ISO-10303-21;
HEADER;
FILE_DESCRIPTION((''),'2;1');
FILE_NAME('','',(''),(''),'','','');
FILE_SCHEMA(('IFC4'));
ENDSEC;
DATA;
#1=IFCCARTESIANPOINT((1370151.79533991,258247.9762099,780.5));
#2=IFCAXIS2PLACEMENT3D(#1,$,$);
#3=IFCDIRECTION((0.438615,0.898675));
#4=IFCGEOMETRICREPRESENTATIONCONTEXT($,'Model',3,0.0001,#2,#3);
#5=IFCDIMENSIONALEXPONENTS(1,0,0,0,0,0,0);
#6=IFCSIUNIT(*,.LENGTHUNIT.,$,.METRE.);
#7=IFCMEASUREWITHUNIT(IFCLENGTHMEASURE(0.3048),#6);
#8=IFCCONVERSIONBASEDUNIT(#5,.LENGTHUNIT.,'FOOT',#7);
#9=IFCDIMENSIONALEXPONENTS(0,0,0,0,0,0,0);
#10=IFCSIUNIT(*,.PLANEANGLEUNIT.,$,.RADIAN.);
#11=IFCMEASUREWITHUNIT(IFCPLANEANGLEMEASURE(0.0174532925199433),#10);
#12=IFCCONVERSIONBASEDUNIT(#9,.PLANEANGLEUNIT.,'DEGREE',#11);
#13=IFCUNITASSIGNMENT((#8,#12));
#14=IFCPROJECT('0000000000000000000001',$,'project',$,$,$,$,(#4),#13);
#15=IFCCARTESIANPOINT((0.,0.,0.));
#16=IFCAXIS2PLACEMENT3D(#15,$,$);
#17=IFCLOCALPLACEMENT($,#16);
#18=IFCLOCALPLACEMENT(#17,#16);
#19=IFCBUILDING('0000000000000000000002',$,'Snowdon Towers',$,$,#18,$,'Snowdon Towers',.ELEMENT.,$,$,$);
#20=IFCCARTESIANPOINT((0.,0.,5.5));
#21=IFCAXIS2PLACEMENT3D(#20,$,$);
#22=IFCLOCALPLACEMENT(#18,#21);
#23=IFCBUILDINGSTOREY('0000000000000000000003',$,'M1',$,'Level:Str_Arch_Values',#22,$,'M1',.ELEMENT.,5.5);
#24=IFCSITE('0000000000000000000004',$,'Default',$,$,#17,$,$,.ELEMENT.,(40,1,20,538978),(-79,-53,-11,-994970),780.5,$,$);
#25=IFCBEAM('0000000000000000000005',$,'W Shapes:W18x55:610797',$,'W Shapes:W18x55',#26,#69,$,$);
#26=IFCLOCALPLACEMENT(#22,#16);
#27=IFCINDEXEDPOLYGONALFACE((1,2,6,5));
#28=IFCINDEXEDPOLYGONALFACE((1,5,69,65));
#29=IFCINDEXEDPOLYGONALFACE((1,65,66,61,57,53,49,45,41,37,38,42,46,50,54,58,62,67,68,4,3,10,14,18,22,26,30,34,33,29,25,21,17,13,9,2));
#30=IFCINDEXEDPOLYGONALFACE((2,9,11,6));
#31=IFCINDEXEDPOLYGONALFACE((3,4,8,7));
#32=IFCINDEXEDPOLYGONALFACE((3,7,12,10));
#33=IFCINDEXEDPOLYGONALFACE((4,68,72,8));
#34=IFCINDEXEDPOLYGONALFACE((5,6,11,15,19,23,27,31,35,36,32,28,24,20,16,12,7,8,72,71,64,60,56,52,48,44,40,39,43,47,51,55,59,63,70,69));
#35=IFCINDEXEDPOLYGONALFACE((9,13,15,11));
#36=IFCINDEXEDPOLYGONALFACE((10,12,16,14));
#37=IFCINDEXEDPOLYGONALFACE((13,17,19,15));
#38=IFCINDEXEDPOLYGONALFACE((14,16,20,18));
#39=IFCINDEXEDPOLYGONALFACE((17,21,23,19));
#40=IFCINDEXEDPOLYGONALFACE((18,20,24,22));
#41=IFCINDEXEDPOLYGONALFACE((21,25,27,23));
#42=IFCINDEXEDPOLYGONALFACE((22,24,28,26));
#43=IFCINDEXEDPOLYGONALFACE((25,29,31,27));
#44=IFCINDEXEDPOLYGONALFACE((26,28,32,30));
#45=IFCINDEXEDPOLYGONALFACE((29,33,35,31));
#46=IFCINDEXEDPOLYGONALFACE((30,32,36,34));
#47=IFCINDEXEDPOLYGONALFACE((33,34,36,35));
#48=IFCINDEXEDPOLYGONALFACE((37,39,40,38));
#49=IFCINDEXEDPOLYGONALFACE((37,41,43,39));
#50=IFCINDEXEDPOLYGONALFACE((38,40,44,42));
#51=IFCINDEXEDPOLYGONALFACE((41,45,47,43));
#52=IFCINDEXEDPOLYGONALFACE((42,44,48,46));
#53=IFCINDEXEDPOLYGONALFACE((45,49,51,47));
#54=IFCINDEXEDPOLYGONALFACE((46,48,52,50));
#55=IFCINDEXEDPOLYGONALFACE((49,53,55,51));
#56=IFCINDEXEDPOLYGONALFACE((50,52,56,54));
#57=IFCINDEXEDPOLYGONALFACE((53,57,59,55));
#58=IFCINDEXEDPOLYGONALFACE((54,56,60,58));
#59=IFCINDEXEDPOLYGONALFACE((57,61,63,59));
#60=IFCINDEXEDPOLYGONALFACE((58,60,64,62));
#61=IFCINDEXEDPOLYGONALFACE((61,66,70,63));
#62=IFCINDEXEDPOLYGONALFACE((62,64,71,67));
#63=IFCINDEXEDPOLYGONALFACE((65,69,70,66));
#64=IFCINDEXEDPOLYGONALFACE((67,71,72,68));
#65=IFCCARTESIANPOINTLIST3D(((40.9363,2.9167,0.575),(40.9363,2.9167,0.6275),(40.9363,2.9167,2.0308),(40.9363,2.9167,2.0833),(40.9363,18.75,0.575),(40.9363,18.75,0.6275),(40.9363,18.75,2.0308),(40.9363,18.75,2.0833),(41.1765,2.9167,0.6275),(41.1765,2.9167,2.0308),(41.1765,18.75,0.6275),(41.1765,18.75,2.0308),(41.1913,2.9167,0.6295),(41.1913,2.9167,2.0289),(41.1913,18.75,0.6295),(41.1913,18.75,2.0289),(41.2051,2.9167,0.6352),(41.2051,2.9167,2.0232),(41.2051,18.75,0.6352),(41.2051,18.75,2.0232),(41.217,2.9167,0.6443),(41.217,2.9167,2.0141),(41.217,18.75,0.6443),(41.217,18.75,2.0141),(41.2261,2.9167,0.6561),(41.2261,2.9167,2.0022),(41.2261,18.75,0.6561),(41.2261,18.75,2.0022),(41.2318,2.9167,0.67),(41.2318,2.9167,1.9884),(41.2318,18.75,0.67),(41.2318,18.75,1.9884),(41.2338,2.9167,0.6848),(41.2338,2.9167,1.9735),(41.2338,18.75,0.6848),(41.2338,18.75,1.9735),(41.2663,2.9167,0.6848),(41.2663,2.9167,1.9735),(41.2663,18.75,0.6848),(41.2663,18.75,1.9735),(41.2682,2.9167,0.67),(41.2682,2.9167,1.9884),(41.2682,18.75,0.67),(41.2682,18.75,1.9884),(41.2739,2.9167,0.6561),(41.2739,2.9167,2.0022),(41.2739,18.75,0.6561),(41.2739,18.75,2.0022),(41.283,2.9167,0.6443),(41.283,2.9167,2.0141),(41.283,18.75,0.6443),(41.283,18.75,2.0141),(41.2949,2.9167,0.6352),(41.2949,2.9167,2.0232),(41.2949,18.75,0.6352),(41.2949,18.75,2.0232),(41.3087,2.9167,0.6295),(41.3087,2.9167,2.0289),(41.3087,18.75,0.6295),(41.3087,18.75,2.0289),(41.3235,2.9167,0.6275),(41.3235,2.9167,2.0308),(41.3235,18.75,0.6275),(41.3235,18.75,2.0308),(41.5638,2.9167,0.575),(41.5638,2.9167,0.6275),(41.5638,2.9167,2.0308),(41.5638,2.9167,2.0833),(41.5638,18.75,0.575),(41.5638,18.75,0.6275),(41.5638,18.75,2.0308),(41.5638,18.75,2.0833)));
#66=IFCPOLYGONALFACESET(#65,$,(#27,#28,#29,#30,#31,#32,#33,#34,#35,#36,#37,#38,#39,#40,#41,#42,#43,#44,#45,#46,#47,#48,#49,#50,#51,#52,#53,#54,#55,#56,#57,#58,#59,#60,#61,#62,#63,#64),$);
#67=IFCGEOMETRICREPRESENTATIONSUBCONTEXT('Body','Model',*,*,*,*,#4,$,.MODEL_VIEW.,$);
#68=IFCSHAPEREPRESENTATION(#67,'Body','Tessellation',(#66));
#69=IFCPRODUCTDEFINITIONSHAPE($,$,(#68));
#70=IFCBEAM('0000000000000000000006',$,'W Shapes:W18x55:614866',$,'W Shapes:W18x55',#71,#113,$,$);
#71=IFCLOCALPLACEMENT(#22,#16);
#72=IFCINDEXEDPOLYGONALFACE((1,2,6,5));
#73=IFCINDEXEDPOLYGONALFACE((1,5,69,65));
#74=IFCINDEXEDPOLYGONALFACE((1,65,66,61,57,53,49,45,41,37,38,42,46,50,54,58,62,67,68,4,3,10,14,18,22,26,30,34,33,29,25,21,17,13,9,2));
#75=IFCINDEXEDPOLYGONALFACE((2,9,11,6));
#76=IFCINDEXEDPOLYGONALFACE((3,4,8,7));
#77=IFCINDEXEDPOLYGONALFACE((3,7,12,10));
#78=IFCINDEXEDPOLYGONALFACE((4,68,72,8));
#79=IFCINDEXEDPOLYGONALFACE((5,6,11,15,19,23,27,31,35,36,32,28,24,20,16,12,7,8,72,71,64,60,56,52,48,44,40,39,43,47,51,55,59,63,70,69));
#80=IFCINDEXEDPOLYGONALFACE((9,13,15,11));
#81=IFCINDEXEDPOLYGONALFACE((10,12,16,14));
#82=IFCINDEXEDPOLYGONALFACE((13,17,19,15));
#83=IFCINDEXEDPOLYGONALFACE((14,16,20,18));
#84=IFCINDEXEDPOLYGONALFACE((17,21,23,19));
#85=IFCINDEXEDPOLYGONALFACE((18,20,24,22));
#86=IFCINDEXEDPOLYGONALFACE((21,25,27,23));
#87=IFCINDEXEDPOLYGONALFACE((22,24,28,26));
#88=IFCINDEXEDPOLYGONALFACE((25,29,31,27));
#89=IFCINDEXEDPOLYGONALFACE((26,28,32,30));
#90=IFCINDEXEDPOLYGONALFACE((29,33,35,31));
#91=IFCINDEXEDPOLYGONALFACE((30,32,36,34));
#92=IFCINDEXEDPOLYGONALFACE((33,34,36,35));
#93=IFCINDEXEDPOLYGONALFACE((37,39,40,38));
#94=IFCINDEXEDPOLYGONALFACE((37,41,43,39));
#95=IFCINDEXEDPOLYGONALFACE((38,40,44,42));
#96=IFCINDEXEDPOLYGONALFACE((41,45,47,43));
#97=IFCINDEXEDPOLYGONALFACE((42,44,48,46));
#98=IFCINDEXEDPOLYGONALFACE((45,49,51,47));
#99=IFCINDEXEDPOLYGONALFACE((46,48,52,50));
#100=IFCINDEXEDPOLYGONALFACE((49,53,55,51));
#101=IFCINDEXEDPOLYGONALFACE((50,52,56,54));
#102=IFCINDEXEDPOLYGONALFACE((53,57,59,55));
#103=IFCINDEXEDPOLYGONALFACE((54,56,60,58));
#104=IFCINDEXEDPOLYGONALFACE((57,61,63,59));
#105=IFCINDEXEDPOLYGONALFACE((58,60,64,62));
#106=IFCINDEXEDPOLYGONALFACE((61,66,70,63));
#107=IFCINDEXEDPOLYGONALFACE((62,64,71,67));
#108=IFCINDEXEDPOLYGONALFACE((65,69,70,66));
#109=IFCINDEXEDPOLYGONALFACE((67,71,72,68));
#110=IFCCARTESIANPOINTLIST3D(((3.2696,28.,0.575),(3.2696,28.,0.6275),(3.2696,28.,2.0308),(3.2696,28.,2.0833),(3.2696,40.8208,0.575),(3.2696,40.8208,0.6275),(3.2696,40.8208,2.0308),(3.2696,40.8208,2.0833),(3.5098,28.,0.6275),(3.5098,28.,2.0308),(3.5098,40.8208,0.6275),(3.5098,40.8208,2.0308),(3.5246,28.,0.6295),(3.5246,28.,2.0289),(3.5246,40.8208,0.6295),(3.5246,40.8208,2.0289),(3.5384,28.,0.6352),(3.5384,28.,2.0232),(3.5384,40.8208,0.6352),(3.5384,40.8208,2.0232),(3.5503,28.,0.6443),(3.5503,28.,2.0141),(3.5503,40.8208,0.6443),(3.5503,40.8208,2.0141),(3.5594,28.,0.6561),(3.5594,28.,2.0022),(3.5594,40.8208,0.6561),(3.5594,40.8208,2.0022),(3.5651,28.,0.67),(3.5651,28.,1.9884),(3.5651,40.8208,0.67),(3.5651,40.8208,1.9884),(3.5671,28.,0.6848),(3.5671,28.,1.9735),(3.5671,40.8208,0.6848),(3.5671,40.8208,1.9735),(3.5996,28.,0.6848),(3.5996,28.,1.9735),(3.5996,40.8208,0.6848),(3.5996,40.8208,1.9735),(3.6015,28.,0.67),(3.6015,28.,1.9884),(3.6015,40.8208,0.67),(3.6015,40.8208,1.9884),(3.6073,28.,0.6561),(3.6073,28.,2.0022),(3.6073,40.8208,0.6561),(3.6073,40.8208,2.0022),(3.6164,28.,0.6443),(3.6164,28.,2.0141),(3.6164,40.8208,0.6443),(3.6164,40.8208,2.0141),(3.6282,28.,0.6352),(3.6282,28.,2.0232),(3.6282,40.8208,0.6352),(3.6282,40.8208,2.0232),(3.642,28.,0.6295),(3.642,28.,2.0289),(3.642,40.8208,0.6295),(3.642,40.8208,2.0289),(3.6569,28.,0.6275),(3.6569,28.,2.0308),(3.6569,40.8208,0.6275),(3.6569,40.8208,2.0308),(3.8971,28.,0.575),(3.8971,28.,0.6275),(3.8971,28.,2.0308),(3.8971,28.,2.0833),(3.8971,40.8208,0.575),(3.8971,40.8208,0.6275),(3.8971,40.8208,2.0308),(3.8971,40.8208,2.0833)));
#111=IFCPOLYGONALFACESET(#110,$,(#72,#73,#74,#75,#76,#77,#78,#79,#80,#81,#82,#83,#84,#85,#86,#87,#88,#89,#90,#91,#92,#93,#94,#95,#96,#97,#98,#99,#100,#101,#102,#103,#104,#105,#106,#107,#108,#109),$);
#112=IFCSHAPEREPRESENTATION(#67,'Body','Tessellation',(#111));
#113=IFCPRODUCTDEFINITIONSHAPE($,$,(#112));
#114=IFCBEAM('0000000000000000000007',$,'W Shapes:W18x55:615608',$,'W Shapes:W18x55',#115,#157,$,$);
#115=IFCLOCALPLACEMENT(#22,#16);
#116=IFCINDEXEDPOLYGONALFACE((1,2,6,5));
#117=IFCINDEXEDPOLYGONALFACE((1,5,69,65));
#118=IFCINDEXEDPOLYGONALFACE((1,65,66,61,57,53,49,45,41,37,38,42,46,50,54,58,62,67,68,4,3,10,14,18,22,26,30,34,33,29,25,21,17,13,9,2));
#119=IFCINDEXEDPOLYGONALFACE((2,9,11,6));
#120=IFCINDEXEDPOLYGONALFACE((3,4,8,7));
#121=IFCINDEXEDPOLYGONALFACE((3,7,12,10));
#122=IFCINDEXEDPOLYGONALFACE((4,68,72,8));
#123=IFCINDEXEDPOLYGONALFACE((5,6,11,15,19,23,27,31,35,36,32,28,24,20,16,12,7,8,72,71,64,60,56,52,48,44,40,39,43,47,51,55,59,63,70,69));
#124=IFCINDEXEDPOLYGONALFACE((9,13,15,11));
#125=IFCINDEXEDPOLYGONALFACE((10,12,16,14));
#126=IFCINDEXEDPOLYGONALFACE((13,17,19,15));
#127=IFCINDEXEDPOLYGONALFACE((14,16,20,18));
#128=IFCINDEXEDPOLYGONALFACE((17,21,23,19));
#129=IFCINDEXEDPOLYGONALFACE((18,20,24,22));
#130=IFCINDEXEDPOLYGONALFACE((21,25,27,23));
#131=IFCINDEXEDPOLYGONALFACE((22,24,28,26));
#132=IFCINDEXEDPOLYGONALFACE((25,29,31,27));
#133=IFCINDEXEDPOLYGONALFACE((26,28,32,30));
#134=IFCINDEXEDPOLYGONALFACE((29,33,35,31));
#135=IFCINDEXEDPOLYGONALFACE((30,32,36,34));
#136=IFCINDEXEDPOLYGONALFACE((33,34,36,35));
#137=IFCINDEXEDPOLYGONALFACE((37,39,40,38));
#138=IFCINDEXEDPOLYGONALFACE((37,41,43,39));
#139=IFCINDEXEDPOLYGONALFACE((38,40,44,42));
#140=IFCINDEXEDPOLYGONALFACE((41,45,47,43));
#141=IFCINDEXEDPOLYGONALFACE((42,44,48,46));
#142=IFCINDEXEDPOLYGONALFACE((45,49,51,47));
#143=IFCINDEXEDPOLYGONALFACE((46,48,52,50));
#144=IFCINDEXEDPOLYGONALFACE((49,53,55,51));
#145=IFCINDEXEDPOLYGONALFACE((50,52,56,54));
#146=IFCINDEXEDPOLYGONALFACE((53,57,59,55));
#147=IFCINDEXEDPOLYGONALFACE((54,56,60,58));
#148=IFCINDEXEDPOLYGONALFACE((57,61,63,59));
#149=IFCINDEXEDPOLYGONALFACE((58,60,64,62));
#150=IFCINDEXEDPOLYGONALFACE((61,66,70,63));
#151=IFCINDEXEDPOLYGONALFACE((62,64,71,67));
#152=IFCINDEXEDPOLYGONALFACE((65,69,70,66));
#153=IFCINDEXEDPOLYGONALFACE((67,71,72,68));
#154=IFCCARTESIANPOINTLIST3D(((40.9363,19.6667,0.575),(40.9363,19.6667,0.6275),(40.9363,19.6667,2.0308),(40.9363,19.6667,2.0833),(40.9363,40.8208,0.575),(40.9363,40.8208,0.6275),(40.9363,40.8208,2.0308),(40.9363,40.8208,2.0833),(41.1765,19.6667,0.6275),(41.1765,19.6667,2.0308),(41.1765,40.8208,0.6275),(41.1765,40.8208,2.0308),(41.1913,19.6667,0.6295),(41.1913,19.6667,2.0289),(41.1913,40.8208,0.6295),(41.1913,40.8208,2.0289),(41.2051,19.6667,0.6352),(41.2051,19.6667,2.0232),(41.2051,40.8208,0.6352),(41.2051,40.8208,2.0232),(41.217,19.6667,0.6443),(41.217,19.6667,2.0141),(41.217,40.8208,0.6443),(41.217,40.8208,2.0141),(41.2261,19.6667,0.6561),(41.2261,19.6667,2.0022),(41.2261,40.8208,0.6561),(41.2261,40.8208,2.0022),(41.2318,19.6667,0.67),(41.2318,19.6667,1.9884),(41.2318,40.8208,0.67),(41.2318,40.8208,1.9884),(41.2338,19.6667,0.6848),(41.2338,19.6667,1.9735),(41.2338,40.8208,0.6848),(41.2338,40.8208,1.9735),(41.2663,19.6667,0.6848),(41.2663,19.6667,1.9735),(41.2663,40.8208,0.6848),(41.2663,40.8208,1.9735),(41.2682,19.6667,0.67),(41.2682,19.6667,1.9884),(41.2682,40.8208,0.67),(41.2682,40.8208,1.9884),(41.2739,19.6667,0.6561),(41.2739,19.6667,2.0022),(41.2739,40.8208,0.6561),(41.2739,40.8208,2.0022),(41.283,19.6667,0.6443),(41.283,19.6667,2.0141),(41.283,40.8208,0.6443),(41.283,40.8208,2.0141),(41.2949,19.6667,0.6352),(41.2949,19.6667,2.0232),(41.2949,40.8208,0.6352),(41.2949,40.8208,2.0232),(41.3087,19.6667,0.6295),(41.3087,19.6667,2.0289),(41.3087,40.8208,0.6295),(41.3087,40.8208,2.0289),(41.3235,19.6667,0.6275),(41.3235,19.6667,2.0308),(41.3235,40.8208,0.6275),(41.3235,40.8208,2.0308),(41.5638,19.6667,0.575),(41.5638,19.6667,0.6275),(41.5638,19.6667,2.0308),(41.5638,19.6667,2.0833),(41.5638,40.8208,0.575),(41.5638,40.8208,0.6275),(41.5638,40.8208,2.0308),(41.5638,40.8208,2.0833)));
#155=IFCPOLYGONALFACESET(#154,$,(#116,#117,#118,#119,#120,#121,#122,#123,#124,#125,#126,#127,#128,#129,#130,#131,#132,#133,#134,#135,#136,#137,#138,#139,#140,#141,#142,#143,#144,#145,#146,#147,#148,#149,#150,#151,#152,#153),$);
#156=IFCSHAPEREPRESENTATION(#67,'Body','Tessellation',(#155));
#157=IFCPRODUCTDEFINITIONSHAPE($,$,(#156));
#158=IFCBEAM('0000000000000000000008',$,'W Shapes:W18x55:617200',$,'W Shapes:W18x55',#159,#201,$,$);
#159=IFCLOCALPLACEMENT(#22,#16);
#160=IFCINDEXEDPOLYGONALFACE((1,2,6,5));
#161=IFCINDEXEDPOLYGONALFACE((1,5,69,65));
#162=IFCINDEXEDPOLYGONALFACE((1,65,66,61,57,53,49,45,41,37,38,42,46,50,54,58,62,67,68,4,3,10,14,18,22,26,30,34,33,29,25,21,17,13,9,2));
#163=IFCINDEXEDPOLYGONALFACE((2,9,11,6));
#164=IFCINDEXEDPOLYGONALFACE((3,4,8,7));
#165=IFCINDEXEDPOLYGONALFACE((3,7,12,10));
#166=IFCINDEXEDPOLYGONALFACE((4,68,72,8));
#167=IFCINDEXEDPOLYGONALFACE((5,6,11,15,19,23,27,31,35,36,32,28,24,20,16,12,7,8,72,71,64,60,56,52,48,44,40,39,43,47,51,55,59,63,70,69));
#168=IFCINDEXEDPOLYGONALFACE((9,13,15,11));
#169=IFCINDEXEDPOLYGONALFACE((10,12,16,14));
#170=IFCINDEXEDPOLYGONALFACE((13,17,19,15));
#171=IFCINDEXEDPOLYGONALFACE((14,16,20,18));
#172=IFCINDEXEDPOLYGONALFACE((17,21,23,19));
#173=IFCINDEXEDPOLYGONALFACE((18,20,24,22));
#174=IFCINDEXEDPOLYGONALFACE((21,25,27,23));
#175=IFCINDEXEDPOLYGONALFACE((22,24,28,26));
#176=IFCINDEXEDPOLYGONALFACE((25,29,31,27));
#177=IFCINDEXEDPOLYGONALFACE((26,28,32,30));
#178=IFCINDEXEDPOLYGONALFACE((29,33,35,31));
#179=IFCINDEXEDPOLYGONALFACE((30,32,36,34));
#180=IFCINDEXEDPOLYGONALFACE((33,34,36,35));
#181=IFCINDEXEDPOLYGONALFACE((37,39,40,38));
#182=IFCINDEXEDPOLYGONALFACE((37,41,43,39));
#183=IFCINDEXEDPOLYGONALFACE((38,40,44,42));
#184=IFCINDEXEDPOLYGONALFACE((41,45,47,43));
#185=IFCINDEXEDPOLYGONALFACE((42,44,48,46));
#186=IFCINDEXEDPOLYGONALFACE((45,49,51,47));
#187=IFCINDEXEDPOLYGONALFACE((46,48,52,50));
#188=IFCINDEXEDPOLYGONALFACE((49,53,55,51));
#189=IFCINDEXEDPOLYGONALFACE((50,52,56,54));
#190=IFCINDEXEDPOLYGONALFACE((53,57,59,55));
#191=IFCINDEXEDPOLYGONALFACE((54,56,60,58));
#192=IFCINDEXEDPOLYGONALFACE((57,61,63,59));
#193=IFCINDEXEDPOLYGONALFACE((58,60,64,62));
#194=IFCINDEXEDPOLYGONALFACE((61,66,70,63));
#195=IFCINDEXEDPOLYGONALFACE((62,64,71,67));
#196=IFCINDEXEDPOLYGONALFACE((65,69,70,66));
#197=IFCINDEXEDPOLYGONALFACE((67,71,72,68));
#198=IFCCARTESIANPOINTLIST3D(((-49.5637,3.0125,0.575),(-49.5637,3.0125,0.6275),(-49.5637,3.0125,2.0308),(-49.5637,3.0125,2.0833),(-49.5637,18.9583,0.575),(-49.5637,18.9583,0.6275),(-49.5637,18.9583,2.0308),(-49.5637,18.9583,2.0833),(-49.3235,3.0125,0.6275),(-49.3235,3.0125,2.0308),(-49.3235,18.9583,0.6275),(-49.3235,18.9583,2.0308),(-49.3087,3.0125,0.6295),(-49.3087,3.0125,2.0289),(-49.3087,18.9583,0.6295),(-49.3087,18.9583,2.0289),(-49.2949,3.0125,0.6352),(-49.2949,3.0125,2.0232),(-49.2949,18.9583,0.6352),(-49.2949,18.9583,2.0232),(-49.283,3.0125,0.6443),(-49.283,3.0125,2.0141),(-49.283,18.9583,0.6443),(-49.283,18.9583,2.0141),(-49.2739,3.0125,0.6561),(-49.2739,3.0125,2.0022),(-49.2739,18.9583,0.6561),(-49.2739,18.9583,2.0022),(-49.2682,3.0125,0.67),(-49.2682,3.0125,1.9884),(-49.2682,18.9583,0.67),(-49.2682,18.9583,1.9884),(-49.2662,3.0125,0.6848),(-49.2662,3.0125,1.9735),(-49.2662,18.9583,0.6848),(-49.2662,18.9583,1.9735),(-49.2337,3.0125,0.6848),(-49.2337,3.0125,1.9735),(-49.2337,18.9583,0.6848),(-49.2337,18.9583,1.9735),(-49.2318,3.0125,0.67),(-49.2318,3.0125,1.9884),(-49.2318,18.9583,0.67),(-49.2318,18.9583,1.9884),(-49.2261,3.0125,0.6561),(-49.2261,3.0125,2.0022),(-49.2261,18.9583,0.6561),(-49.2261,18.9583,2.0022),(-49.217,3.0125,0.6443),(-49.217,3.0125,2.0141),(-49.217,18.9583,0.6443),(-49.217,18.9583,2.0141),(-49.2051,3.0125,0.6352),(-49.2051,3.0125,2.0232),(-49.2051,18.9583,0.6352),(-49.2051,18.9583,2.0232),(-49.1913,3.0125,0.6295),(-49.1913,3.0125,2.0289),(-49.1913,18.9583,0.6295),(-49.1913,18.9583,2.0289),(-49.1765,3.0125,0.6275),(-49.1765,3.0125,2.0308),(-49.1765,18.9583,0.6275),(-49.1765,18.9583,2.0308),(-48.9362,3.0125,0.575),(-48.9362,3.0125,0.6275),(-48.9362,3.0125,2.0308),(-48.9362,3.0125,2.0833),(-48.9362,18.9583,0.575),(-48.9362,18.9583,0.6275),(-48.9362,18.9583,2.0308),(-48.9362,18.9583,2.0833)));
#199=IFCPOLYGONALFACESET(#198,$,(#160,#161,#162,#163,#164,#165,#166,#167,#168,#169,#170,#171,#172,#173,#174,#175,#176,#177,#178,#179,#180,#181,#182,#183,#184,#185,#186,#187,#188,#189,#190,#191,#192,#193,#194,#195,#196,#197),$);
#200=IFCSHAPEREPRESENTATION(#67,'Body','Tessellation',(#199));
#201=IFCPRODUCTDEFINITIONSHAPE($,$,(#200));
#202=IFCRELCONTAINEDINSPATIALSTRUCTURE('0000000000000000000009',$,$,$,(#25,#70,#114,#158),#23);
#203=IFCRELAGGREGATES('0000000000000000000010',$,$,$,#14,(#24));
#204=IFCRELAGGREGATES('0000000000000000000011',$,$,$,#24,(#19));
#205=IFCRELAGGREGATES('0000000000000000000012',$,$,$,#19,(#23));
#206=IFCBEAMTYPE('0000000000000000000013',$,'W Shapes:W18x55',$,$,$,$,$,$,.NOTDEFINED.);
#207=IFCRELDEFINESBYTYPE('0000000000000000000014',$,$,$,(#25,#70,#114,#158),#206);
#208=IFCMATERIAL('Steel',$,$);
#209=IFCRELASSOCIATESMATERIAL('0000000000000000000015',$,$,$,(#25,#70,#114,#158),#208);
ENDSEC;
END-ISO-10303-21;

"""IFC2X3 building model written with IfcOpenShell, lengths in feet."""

from ifc_helpers import new_model, entity, si_unit, converted_unit, direction, frame, frame_2d, origin, place, context, subcontext, project, spatial, i_section, extrude, material, type_object, element, save


model = new_model("IFC2X3")

# Units and contexts
model_context = context("Model", 3, precision=0.0001, world=frame((1370151.79533991, 258247.9762099, 780.5)), true_north=direction((0.438615, 0.898675)))
body_context = subcontext(model_context, "Body", "Model", "MODEL_VIEW")
ifc_project = project(units=[converted_unit("LENGTHUNIT", "FOOT", entity("IfcLengthMeasure", 0.3048), si_unit("LENGTHUNIT", "METRE"), dimensions=[1, 0, 0, 0, 0, 0, 0]), converted_unit("PLANEANGLEUNIT", "DEGREE", entity("IfcPlaneAngleMeasure", 0.0174532925199433), si_unit("PLANEANGLEUNIT", "RADIAN"), dimensions=[0, 0, 0, 0, 0, 0, 0])], contexts=[model_context])

# Site, building, storey
site_placement = place(None, origin())
site = spatial("IfcSite", under=ifc_project, at=site_placement, Name="Default", CompositionType="ELEMENT", RefLatitude=(40, 1, 20, 538978), RefLongitude=(-79, -53, -11, -994970), RefElevation=780.5)
building_placement = place(site_placement, origin())
building = spatial("IfcBuilding", under=site, at=building_placement, Name="Snowdon Towers", LongName="Snowdon Towers", CompositionType="ELEMENT")
storey_placement = place(building_placement, frame((0.0, 0.0, 5.5)))
storey = spatial("IfcBuildingStorey", under=building, at=storey_placement, Name="M1", ObjectType="Level:Str_Arch_Values", LongName="M1", CompositionType="ELEMENT", Elevation=5.5)

# Beams
ifc_material_1 = material(Name="Steel")
beam_type_1 = type_object("IfcBeamType", Name="W Shapes:W18x55", PredefinedType="NOTDEFINED")
beam_1_placement = place(storey_placement, frame((41.25, 2.375, 2.0833), z_axis=(0.0, 0.0, 1.0), x_axis=(0.0, 1.0, 0.0)))
element("IfcBeam", 1, at=beam_1_placement, inside=storey, type_object=beam_type_1, material=ifc_material_1, Name="W Shapes:W18x55:610797", ObjectType="W Shapes:W18x55", context=body_context, shape_type="SweptSolid", body=[
    extrude(i_section(OverallWidth=0.6275, OverallDepth=1.5083, WebThickness=0.0325, FlangeThickness=0.0525, FilletRadius=0.0573, at=frame_2d((0.0, 0.0), x_axis=(0.0, 1.0))), frame((0.5417, 0.0, -0.7542), z_axis=(1.0, 0.0, 0.0), x_axis=(0.0, 0.0, -1.0)), (0.0, 0.0, 1.0), 15.8333),
])
beam_2_placement = place(storey_placement, frame((3.5833, 27.5417, 2.0833), z_axis=(0.0, 0.0, 1.0), x_axis=(0.0, 1.0, 0.0)))
element("IfcBeam", 2, at=beam_2_placement, inside=storey, type_object=beam_type_1, material=ifc_material_1, Name="W Shapes:W18x55:614866", ObjectType="W Shapes:W18x55", context=body_context, shape_type="SweptSolid", body=[
    extrude(i_section(OverallWidth=0.6275, OverallDepth=1.5083, WebThickness=0.0325, FlangeThickness=0.0525, FilletRadius=0.0573, at=frame_2d((0.0, 0.0), x_axis=(0.0, 1.0))), frame((0.4583, 0.0, -0.7542), z_axis=(1.0, 0.0, 0.0), x_axis=(0.0, 0.0, -1.0)), (0.0, 0.0, 1.0), 12.8208),
])
beam_3_placement = place(storey_placement, frame((41.25, 19.2083, 2.0833), z_axis=(0.0, 0.0, 1.0), x_axis=(0.0, 1.0, 0.0)))
element("IfcBeam", 3, at=beam_3_placement, inside=storey, type_object=beam_type_1, material=ifc_material_1, Name="W Shapes:W18x55:615608", ObjectType="W Shapes:W18x55", context=body_context, shape_type="SweptSolid", body=[
    extrude(i_section(OverallWidth=0.6275, OverallDepth=1.5083, WebThickness=0.0325, FlangeThickness=0.0525, FilletRadius=0.0573, at=frame_2d((0.0, 0.0), x_axis=(0.0, 1.0))), frame((0.4583, 0.0, -0.7542), z_axis=(1.0, 0.0, 0.0), x_axis=(0.0, 0.0, -1.0)), (0.0, 0.0, 1.0), 21.1542),
])
beam_4_placement = place(storey_placement, frame((-49.25, 2.5, 2.0833), z_axis=(0.0, 0.0, 1.0), x_axis=(0.0, 1.0, 0.0)))
element("IfcBeam", 4, at=beam_4_placement, inside=storey, type_object=beam_type_1, material=ifc_material_1, Name="W Shapes:W18x55:617200", ObjectType="W Shapes:W18x55", context=body_context, shape_type="SweptSolid", body=[
    extrude(i_section(OverallWidth=0.6275, OverallDepth=1.5083, WebThickness=0.0325, FlangeThickness=0.0525, FilletRadius=0.0573, at=frame_2d((0.0, 0.0), x_axis=(0.0, 1.0))), frame((0.5125, 0.0, -0.7542), z_axis=(1.0, 0.0, 0.0), x_axis=(0.0, 0.0, -1.0)), (0.0, 0.0, 1.0), 15.9458),
])

save(model, "model.ifc")
